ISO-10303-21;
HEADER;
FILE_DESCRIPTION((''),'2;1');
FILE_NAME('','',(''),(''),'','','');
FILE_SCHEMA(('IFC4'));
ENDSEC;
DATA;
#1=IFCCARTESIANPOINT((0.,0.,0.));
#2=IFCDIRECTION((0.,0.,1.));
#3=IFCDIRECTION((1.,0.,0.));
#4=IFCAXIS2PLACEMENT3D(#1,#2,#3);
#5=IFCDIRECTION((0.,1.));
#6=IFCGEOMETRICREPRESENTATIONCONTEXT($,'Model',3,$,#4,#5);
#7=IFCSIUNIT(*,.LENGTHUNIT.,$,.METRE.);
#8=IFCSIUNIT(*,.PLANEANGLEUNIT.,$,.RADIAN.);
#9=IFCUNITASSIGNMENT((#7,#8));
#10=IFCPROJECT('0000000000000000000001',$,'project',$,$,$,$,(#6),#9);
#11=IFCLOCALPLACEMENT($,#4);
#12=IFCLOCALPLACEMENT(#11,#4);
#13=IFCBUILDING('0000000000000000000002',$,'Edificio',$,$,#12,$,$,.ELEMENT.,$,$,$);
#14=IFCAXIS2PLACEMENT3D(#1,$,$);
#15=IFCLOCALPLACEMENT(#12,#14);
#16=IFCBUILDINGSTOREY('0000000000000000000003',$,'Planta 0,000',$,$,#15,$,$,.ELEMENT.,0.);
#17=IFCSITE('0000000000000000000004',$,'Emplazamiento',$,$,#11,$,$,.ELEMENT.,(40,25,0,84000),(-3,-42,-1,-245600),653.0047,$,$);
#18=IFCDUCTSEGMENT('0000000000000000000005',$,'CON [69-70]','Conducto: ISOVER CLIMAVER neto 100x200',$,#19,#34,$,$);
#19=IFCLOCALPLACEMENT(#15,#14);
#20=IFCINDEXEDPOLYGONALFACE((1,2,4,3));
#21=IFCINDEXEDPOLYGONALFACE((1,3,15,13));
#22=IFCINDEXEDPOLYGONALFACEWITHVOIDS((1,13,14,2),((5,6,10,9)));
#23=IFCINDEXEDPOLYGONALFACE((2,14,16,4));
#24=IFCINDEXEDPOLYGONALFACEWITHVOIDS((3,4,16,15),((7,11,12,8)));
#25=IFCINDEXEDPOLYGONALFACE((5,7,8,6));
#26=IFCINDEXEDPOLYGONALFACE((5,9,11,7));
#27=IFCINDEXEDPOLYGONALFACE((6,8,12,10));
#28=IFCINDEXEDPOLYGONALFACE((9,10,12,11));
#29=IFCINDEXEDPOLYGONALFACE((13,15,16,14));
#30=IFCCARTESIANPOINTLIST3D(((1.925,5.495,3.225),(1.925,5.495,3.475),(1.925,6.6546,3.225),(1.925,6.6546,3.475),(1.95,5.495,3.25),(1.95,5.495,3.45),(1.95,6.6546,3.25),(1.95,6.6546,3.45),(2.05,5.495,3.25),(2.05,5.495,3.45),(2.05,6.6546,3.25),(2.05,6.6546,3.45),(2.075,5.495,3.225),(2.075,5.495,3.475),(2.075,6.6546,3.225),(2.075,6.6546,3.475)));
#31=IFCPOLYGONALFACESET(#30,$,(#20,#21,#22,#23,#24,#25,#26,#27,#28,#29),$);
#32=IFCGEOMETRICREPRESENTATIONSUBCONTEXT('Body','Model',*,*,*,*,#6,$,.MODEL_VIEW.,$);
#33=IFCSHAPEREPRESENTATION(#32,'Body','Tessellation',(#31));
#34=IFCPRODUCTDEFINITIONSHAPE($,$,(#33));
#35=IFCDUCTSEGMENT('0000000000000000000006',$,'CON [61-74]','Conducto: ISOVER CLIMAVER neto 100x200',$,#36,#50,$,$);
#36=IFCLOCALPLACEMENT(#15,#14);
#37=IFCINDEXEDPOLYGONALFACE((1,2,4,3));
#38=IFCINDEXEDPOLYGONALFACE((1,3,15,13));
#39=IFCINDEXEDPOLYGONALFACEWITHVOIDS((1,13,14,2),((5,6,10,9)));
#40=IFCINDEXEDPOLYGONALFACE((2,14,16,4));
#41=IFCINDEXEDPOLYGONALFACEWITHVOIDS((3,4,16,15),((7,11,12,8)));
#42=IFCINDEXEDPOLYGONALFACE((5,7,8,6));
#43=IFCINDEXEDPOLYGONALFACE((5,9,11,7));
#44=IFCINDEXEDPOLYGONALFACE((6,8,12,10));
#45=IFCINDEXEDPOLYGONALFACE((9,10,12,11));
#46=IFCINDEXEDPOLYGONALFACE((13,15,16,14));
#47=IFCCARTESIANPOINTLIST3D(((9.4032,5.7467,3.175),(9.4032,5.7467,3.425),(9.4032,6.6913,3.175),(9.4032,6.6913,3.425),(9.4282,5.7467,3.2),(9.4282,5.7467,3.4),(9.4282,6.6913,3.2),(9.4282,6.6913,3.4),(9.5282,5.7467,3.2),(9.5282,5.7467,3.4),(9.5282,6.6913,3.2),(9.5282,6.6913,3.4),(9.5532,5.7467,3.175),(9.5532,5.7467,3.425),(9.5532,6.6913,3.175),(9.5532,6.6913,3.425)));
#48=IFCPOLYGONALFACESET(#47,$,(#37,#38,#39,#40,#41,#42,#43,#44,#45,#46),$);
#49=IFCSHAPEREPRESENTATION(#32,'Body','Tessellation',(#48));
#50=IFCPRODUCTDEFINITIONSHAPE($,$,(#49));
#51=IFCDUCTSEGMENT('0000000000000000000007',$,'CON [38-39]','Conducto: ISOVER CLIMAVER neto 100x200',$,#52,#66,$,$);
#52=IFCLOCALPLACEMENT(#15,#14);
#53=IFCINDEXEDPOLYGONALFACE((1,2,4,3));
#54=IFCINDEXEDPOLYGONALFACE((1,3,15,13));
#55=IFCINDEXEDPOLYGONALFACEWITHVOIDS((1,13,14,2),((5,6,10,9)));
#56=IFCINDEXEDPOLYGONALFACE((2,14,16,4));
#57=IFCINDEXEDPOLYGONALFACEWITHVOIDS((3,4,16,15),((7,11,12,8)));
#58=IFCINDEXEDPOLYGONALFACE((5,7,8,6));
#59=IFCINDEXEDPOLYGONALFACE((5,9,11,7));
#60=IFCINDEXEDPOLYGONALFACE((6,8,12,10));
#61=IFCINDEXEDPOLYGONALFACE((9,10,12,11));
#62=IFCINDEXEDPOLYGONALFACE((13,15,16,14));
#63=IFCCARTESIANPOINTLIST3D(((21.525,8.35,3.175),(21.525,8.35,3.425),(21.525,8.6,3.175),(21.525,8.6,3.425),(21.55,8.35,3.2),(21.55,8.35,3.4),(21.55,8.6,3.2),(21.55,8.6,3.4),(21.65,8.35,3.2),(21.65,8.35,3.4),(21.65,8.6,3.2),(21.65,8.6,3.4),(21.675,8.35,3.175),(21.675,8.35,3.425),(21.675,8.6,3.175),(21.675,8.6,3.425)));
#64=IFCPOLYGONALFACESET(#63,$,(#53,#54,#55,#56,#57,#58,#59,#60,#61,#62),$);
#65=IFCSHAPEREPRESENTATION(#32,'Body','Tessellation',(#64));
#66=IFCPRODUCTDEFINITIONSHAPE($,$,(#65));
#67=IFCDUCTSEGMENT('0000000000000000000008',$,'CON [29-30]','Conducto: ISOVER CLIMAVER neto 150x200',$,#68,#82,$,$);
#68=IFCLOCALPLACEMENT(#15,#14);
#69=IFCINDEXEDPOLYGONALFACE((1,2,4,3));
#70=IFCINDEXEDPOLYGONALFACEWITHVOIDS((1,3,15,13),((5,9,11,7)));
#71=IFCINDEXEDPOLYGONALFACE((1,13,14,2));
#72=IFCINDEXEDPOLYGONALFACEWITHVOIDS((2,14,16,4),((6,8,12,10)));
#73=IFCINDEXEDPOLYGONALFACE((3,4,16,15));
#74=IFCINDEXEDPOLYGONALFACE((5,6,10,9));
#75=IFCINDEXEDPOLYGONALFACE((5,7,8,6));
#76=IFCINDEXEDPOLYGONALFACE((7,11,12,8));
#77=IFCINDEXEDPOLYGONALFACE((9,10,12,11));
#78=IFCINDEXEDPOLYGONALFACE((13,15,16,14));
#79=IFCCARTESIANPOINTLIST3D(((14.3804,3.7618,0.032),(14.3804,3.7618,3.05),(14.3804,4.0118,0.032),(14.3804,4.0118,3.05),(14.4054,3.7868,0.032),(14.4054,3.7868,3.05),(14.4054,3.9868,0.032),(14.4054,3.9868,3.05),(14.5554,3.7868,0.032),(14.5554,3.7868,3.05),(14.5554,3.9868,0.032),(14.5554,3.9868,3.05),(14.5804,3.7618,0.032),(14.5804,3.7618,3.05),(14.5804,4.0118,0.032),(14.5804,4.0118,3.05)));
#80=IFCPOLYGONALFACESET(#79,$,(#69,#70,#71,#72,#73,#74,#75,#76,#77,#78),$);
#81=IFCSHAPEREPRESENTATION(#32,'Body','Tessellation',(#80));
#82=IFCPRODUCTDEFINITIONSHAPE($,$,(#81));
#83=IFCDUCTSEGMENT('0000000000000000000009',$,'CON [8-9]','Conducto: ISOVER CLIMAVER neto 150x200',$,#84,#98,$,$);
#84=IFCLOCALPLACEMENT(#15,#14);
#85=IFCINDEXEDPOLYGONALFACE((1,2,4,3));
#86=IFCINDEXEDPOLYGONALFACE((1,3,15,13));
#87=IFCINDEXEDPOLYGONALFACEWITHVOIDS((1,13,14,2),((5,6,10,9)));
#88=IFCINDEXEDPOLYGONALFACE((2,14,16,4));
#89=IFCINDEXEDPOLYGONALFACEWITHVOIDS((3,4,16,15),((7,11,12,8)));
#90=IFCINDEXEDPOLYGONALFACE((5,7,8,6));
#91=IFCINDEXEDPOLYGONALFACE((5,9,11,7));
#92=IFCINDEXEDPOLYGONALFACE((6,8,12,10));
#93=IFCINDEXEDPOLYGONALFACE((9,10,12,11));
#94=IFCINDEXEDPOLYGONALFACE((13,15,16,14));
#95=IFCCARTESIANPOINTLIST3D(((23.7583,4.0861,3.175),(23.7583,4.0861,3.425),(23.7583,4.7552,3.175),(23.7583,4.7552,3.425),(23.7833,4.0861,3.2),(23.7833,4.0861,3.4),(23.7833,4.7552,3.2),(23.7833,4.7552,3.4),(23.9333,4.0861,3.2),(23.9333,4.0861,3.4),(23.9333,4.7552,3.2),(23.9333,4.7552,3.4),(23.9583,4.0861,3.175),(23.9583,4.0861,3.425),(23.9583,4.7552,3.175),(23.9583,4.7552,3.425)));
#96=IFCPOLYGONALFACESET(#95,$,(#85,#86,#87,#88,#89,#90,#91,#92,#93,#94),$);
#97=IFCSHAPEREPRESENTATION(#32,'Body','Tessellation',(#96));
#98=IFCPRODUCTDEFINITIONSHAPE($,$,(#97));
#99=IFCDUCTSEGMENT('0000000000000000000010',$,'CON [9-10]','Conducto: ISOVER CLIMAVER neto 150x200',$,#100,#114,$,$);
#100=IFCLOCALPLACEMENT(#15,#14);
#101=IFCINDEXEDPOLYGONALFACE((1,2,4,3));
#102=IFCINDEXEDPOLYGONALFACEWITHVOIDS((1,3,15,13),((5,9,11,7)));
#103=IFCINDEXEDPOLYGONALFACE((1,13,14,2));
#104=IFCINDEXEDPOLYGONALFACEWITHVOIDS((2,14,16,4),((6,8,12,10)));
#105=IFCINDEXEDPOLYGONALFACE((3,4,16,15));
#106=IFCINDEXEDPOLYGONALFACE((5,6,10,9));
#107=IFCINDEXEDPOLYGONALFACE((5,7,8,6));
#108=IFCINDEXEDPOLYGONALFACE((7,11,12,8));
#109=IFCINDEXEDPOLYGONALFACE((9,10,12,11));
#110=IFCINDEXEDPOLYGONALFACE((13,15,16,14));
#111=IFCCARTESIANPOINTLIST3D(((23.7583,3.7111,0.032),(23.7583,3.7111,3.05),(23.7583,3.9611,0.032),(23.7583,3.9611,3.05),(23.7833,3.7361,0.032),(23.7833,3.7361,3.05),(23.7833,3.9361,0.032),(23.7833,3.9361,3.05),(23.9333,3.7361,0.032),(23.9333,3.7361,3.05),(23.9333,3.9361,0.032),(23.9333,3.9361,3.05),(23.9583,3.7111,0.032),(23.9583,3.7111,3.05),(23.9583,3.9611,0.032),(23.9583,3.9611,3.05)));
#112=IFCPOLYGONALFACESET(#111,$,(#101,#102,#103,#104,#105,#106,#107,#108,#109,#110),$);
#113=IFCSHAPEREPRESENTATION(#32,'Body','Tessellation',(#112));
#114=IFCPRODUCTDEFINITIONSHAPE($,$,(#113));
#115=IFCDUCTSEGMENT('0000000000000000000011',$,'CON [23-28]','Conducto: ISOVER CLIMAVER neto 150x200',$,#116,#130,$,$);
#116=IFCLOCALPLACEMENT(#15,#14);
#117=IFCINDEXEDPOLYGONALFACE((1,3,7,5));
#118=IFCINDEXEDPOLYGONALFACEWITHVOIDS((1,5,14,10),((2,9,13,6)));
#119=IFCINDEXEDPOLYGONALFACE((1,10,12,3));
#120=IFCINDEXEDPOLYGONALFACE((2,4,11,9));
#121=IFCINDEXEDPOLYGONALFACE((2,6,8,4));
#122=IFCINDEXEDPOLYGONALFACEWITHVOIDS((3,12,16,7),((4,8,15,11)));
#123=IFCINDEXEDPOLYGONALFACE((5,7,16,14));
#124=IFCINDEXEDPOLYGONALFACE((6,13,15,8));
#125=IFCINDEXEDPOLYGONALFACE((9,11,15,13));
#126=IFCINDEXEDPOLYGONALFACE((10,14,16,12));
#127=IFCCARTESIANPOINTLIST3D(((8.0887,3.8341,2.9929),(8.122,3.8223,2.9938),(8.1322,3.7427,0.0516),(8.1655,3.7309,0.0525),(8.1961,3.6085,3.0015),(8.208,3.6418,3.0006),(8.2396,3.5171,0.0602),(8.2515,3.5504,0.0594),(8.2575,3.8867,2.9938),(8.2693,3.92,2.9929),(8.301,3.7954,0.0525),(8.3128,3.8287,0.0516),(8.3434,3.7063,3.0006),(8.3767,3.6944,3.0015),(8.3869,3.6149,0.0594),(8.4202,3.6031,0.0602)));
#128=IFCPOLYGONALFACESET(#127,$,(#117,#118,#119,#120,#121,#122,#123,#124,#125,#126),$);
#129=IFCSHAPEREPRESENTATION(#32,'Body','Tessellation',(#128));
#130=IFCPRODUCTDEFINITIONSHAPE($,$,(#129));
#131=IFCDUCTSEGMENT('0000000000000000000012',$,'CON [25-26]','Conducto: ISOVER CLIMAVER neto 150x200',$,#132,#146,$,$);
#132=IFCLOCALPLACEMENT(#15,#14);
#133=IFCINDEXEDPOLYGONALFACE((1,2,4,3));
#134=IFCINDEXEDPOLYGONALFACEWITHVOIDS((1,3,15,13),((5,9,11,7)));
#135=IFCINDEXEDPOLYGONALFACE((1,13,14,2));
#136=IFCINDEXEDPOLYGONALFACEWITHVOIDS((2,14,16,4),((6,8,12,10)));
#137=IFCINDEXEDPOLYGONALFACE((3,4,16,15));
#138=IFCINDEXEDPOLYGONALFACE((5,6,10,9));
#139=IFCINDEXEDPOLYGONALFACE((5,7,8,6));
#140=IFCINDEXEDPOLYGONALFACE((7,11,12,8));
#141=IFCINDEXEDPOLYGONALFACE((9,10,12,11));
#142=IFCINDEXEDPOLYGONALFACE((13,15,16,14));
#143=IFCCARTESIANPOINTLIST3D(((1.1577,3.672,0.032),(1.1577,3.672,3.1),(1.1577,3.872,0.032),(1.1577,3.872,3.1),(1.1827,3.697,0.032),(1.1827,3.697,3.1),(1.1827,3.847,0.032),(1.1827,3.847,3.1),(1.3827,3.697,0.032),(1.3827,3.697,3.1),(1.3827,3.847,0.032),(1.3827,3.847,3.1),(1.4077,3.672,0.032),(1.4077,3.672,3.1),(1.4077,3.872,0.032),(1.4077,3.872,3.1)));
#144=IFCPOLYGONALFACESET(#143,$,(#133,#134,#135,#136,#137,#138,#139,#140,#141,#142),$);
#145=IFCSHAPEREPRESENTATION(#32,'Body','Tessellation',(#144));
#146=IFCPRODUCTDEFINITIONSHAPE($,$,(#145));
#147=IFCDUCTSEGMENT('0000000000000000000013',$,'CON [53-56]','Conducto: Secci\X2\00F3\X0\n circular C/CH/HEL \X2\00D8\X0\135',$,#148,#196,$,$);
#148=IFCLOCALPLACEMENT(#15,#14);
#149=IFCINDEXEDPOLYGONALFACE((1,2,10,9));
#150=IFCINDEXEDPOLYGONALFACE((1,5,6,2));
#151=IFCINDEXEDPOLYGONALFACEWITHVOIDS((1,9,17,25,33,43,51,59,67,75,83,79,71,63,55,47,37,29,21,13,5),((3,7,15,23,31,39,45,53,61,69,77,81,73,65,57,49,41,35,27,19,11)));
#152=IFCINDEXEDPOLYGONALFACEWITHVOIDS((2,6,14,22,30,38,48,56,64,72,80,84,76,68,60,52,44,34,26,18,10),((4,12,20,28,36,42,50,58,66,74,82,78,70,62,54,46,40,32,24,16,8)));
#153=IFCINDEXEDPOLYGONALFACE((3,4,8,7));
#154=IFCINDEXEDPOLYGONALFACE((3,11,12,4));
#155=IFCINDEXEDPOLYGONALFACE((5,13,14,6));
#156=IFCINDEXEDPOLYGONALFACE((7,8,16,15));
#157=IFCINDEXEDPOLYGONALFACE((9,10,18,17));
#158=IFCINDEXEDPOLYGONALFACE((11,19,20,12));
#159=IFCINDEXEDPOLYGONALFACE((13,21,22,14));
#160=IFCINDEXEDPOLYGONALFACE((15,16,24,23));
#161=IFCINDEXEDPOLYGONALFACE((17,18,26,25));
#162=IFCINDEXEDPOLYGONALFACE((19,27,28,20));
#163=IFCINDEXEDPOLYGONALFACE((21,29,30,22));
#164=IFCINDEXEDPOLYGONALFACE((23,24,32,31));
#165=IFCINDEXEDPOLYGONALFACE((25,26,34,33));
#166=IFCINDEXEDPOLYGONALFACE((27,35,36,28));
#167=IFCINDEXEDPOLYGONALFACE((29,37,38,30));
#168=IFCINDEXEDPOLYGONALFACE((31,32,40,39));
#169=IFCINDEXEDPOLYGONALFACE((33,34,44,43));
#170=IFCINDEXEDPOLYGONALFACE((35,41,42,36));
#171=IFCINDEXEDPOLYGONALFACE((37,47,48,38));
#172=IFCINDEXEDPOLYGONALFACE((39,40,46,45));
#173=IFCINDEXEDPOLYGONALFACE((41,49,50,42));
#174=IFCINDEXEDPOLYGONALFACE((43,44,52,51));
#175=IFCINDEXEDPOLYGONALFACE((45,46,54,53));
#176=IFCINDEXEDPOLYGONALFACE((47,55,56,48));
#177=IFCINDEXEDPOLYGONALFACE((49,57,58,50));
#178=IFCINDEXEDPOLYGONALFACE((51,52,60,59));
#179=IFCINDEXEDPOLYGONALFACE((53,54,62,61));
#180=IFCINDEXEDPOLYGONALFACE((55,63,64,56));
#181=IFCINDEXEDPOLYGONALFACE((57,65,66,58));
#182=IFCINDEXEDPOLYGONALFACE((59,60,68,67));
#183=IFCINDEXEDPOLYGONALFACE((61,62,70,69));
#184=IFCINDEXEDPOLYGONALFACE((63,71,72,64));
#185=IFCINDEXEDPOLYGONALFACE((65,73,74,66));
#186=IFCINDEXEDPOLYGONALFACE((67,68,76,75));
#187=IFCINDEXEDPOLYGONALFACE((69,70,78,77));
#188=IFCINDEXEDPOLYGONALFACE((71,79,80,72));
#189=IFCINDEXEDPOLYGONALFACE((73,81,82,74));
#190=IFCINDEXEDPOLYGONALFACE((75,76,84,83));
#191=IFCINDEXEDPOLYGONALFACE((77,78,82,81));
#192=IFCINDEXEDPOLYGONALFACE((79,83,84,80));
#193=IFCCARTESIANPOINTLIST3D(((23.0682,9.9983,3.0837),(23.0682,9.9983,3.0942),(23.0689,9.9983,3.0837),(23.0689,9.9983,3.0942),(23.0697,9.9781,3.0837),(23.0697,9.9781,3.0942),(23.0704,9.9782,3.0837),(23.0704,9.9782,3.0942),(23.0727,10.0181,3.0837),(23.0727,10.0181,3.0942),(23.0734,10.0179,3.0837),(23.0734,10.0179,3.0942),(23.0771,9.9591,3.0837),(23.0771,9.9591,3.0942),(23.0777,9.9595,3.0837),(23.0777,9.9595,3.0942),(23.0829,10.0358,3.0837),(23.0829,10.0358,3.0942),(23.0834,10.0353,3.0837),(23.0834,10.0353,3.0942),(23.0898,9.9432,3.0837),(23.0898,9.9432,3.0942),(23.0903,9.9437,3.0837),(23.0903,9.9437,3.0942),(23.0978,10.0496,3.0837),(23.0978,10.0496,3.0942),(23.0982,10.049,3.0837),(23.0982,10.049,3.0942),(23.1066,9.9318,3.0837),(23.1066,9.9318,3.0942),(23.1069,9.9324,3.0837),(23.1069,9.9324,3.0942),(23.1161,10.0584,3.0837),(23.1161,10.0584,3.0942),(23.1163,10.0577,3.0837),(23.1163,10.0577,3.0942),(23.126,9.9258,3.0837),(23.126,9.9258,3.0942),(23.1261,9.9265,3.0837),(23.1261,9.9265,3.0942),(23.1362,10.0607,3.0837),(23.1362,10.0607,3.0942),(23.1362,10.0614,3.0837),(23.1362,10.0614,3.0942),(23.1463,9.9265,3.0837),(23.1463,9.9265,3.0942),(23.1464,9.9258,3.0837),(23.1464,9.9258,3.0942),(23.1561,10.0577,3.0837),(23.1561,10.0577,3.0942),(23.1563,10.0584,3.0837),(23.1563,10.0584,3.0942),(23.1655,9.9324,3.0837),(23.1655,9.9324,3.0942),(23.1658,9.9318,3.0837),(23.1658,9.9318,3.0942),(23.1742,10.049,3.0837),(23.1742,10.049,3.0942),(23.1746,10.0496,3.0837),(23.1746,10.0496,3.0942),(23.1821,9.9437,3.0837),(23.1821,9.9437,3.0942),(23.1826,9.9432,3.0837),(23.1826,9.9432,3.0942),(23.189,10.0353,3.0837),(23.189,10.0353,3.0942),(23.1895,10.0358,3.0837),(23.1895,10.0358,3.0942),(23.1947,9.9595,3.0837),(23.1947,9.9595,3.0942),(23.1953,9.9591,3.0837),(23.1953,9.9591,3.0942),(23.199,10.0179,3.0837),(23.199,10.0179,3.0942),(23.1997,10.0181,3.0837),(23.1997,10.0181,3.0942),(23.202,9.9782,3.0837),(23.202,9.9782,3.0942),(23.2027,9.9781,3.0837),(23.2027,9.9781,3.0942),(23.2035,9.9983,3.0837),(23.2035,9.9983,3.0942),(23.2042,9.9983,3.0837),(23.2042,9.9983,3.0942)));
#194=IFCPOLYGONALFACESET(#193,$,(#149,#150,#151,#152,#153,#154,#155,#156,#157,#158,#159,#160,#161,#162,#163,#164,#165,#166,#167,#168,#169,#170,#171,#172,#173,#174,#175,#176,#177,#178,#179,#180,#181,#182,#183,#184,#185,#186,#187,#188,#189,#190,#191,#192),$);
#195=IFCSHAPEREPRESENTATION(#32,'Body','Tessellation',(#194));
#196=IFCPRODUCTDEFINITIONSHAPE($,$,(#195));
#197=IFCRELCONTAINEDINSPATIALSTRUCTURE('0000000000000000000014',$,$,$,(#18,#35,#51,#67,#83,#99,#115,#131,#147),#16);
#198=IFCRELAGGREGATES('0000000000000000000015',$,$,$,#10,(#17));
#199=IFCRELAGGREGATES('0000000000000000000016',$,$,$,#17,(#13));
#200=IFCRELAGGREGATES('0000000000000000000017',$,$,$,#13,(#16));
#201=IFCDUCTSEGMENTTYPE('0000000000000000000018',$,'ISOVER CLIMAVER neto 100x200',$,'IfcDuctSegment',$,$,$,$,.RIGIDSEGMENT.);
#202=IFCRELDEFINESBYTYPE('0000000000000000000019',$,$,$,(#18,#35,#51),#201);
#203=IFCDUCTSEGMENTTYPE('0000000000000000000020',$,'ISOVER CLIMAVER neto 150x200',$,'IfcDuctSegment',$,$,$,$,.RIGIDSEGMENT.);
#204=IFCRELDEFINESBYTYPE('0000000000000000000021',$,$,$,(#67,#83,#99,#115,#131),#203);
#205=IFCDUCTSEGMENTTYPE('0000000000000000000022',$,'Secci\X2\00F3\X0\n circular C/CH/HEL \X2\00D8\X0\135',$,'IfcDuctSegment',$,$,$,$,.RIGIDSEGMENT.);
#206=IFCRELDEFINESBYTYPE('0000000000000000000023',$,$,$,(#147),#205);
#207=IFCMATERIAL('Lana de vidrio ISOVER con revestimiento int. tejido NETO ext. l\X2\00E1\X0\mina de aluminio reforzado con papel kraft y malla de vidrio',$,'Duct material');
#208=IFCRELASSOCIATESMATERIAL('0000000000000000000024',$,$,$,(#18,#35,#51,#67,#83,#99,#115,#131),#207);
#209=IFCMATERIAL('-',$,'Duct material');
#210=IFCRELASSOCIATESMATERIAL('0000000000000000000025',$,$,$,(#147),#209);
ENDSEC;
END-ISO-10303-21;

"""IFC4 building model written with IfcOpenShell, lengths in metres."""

from ifc_helpers import new_model, si_unit, direction, frame, origin, origin_with_axes, origin_2d_with_axis, place, context, subcontext, project, spatial, hollow_rectangle, hollow_circle, extrude, material, type_object, element, save


model = new_model("IFC4")

# Units and contexts
model_context = context("Model", 3, world=origin_with_axes(), true_north=direction((0.0, 1.0)))
body_context = subcontext(model_context, "Body", "Model", "MODEL_VIEW")
ifc_project = project(units=[si_unit("LENGTHUNIT", "METRE"), si_unit("PLANEANGLEUNIT", "RADIAN")], contexts=[model_context])

# Site, building, storey
site_placement = place(None, origin_with_axes())
site = spatial("IfcSite", under=ifc_project, at=site_placement, Name="Emplazamiento", CompositionType="ELEMENT", RefLatitude=(40, 25, 0, 84000), RefLongitude=(-3, -42, -1, -245600), RefElevation=653.0047)
building_placement = place(site_placement, origin_with_axes())
building = spatial("IfcBuilding", under=site, at=building_placement, Name="Edificio", CompositionType="ELEMENT")
storey_placement = place(building_placement, origin())
storey = spatial("IfcBuildingStorey", under=building, at=storey_placement, Name="Planta 0,000", CompositionType="ELEMENT", Elevation=0.0)

# Shared definitions
ifc_material_1 = material(Name="-", Category="Duct material")

# Duct segments
ifc_material_2 = material(Name="Lana de vidrio ISOVER con revestimiento int. tejido NETO ext. lámina de aluminio reforzado con papel kraft y malla de vidrio", Category="Duct material")
duct_segment_type_1 = type_object("IfcDuctSegmentType", Name="ISOVER CLIMAVER neto 100x200", ApplicableOccurrence="IfcDuctSegment", PredefinedType="RIGIDSEGMENT")
duct_segment_1_placement = place(storey_placement, origin_with_axes())
element("IfcDuctSegment", 1, at=duct_segment_1_placement, inside=storey, type_object=duct_segment_type_1, material=ifc_material_2, Name="CON [69-70]", Description="Conducto: ISOVER CLIMAVER neto 100x200", context=body_context, shape_type="SweptSolid", body=[
    extrude(hollow_rectangle(XDim=0.15, YDim=0.25, WallThickness=0.025, at=origin_2d_with_axis()), frame((2.0, 6.6546, 3.35), z_axis=(0.0, -1.0, 0.0), x_axis=(1.0, 0.0, 0.0)), (0.0, 0.0, 1.0), 1.1596),
])
duct_segment_2_placement = place(storey_placement, origin_with_axes())
element("IfcDuctSegment", 2, at=duct_segment_2_placement, inside=storey, type_object=duct_segment_type_1, material=ifc_material_2, Name="CON [61-74]", Description="Conducto: ISOVER CLIMAVER neto 100x200", context=body_context, shape_type="SweptSolid", body=[
    extrude(hollow_rectangle(XDim=0.15, YDim=0.25, WallThickness=0.025, at=origin_2d_with_axis()), frame((9.4782, 6.6913, 3.3), z_axis=(0.0, -1.0, 0.0), x_axis=(1.0, 0.0, 0.0)), (0.0, 0.0, 1.0), 0.9446),
])
duct_segment_3_placement = place(storey_placement, origin_with_axes())
element("IfcDuctSegment", 3, at=duct_segment_3_placement, inside=storey, type_object=duct_segment_type_1, material=ifc_material_2, Name="CON [38-39]", Description="Conducto: ISOVER CLIMAVER neto 100x200", context=body_context, shape_type="SweptSolid", body=[
    extrude(hollow_rectangle(XDim=0.15, YDim=0.25, WallThickness=0.025, at=origin_2d_with_axis()), frame((21.6, 8.35, 3.3), z_axis=(0.0, 1.0, 0.0), x_axis=(-1.0, 0.0, 0.0)), (0.0, 0.0, 1.0), 0.25),
])

# Duct segments
duct_segment_type_2 = type_object("IfcDuctSegmentType", Name="ISOVER CLIMAVER neto 150x200", ApplicableOccurrence="IfcDuctSegment", PredefinedType="RIGIDSEGMENT")
duct_segment_4_placement = place(storey_placement, origin_with_axes())
element("IfcDuctSegment", 4, at=duct_segment_4_placement, inside=storey, type_object=duct_segment_type_2, material=ifc_material_2, Name="CON [29-30]", Description="Conducto: ISOVER CLIMAVER neto 150x200", context=body_context, shape_type="SweptSolid", body=[
    extrude(hollow_rectangle(XDim=0.2, YDim=0.25, WallThickness=0.025, at=origin_2d_with_axis()), frame((14.4804, 3.8868, 3.05), z_axis=(0.0, 0.0, -1.0), x_axis=(1.0, 0.0, 0.0)), (0.0, 0.0, 1.0), 3.018),
])
duct_segment_5_placement = place(storey_placement, origin_with_axes())
element("IfcDuctSegment", 5, at=duct_segment_5_placement, inside=storey, type_object=duct_segment_type_2, material=ifc_material_2, Name="CON [8-9]", Description="Conducto: ISOVER CLIMAVER neto 150x200", context=body_context, shape_type="SweptSolid", body=[
    extrude(hollow_rectangle(XDim=0.2, YDim=0.25, WallThickness=0.025, at=origin_2d_with_axis()), frame((23.8583, 4.7552, 3.3), z_axis=(0.0, -1.0, 0.0), x_axis=(1.0, 0.0, 0.0)), (0.0, 0.0, 1.0), 0.6691),
])
duct_segment_6_placement = place(storey_placement, origin_with_axes())
element("IfcDuctSegment", 6, at=duct_segment_6_placement, inside=storey, type_object=duct_segment_type_2, material=ifc_material_2, Name="CON [9-10]", Description="Conducto: ISOVER CLIMAVER neto 150x200", context=body_context, shape_type="SweptSolid", body=[
    extrude(hollow_rectangle(XDim=0.2, YDim=0.25, WallThickness=0.025, at=origin_2d_with_axis()), frame((23.8583, 3.8361, 3.05), z_axis=(0.0, 0.0, -1.0), x_axis=(1.0, 0.0, 0.0)), (0.0, 0.0, 1.0), 3.018),
])
duct_segment_7_placement = place(storey_placement, origin_with_axes())
element("IfcDuctSegment", 7, at=duct_segment_7_placement, inside=storey, type_object=duct_segment_type_2, material=ifc_material_2, Name="CON [23-28]", Description="Conducto: ISOVER CLIMAVER neto 150x200", context=body_context, shape_type="SweptSolid", body=[
    extrude(hollow_rectangle(XDim=0.2, YDim=0.25, WallThickness=0.025, at=origin_2d_with_axis()), frame((8.2327, 3.7643, 2.9972), z_axis=(0.014783, -0.031052, -0.999408), x_axis=(0.902904, 0.429843, 0.0)), (0.0, 0.0, 1.0), 2.943),
])
duct_segment_8_placement = place(storey_placement, origin_with_axes())
element("IfcDuctSegment", 8, at=duct_segment_8_placement, inside=storey, type_object=duct_segment_type_2, material=ifc_material_2, Name="CON [25-26]", Description="Conducto: ISOVER CLIMAVER neto 150x200", context=body_context, shape_type="SweptSolid", body=[
    extrude(hollow_rectangle(XDim=0.2, YDim=0.25, WallThickness=0.025, at=origin_2d_with_axis()), frame((1.2827, 3.772, 3.1), z_axis=(0.0, 0.0, -1.0), x_axis=(0.000037, -1.0, 0.0)), (0.0, 0.0, 1.0), 3.068),
])
duct_segment_type_3 = type_object("IfcDuctSegmentType", Name="Sección circular C/CH/HEL Ø135", ApplicableOccurrence="IfcDuctSegment", PredefinedType="RIGIDSEGMENT")
duct_segment_9_placement = place(storey_placement, origin_with_axes())
element("IfcDuctSegment", 9, at=duct_segment_9_placement, inside=storey, type_object=duct_segment_type_3, material=ifc_material_1, Name="CON [53-56]", Description="Conducto: Sección circular C/CH/HEL Ø135", context=body_context, shape_type="SweptSolid", body=[
    extrude(hollow_circle(Radius=0.0682, WallThickness=0.0007, at=origin_2d_with_axis()), frame((23.1362, 9.9932, 3.0942), z_axis=(0.0, 0.0, -1.0), x_axis=(0.0, 1.0, 0.0)), (0.0, 0.0, 1.0), 0.0104),
])

save(model, "model.ifc")
